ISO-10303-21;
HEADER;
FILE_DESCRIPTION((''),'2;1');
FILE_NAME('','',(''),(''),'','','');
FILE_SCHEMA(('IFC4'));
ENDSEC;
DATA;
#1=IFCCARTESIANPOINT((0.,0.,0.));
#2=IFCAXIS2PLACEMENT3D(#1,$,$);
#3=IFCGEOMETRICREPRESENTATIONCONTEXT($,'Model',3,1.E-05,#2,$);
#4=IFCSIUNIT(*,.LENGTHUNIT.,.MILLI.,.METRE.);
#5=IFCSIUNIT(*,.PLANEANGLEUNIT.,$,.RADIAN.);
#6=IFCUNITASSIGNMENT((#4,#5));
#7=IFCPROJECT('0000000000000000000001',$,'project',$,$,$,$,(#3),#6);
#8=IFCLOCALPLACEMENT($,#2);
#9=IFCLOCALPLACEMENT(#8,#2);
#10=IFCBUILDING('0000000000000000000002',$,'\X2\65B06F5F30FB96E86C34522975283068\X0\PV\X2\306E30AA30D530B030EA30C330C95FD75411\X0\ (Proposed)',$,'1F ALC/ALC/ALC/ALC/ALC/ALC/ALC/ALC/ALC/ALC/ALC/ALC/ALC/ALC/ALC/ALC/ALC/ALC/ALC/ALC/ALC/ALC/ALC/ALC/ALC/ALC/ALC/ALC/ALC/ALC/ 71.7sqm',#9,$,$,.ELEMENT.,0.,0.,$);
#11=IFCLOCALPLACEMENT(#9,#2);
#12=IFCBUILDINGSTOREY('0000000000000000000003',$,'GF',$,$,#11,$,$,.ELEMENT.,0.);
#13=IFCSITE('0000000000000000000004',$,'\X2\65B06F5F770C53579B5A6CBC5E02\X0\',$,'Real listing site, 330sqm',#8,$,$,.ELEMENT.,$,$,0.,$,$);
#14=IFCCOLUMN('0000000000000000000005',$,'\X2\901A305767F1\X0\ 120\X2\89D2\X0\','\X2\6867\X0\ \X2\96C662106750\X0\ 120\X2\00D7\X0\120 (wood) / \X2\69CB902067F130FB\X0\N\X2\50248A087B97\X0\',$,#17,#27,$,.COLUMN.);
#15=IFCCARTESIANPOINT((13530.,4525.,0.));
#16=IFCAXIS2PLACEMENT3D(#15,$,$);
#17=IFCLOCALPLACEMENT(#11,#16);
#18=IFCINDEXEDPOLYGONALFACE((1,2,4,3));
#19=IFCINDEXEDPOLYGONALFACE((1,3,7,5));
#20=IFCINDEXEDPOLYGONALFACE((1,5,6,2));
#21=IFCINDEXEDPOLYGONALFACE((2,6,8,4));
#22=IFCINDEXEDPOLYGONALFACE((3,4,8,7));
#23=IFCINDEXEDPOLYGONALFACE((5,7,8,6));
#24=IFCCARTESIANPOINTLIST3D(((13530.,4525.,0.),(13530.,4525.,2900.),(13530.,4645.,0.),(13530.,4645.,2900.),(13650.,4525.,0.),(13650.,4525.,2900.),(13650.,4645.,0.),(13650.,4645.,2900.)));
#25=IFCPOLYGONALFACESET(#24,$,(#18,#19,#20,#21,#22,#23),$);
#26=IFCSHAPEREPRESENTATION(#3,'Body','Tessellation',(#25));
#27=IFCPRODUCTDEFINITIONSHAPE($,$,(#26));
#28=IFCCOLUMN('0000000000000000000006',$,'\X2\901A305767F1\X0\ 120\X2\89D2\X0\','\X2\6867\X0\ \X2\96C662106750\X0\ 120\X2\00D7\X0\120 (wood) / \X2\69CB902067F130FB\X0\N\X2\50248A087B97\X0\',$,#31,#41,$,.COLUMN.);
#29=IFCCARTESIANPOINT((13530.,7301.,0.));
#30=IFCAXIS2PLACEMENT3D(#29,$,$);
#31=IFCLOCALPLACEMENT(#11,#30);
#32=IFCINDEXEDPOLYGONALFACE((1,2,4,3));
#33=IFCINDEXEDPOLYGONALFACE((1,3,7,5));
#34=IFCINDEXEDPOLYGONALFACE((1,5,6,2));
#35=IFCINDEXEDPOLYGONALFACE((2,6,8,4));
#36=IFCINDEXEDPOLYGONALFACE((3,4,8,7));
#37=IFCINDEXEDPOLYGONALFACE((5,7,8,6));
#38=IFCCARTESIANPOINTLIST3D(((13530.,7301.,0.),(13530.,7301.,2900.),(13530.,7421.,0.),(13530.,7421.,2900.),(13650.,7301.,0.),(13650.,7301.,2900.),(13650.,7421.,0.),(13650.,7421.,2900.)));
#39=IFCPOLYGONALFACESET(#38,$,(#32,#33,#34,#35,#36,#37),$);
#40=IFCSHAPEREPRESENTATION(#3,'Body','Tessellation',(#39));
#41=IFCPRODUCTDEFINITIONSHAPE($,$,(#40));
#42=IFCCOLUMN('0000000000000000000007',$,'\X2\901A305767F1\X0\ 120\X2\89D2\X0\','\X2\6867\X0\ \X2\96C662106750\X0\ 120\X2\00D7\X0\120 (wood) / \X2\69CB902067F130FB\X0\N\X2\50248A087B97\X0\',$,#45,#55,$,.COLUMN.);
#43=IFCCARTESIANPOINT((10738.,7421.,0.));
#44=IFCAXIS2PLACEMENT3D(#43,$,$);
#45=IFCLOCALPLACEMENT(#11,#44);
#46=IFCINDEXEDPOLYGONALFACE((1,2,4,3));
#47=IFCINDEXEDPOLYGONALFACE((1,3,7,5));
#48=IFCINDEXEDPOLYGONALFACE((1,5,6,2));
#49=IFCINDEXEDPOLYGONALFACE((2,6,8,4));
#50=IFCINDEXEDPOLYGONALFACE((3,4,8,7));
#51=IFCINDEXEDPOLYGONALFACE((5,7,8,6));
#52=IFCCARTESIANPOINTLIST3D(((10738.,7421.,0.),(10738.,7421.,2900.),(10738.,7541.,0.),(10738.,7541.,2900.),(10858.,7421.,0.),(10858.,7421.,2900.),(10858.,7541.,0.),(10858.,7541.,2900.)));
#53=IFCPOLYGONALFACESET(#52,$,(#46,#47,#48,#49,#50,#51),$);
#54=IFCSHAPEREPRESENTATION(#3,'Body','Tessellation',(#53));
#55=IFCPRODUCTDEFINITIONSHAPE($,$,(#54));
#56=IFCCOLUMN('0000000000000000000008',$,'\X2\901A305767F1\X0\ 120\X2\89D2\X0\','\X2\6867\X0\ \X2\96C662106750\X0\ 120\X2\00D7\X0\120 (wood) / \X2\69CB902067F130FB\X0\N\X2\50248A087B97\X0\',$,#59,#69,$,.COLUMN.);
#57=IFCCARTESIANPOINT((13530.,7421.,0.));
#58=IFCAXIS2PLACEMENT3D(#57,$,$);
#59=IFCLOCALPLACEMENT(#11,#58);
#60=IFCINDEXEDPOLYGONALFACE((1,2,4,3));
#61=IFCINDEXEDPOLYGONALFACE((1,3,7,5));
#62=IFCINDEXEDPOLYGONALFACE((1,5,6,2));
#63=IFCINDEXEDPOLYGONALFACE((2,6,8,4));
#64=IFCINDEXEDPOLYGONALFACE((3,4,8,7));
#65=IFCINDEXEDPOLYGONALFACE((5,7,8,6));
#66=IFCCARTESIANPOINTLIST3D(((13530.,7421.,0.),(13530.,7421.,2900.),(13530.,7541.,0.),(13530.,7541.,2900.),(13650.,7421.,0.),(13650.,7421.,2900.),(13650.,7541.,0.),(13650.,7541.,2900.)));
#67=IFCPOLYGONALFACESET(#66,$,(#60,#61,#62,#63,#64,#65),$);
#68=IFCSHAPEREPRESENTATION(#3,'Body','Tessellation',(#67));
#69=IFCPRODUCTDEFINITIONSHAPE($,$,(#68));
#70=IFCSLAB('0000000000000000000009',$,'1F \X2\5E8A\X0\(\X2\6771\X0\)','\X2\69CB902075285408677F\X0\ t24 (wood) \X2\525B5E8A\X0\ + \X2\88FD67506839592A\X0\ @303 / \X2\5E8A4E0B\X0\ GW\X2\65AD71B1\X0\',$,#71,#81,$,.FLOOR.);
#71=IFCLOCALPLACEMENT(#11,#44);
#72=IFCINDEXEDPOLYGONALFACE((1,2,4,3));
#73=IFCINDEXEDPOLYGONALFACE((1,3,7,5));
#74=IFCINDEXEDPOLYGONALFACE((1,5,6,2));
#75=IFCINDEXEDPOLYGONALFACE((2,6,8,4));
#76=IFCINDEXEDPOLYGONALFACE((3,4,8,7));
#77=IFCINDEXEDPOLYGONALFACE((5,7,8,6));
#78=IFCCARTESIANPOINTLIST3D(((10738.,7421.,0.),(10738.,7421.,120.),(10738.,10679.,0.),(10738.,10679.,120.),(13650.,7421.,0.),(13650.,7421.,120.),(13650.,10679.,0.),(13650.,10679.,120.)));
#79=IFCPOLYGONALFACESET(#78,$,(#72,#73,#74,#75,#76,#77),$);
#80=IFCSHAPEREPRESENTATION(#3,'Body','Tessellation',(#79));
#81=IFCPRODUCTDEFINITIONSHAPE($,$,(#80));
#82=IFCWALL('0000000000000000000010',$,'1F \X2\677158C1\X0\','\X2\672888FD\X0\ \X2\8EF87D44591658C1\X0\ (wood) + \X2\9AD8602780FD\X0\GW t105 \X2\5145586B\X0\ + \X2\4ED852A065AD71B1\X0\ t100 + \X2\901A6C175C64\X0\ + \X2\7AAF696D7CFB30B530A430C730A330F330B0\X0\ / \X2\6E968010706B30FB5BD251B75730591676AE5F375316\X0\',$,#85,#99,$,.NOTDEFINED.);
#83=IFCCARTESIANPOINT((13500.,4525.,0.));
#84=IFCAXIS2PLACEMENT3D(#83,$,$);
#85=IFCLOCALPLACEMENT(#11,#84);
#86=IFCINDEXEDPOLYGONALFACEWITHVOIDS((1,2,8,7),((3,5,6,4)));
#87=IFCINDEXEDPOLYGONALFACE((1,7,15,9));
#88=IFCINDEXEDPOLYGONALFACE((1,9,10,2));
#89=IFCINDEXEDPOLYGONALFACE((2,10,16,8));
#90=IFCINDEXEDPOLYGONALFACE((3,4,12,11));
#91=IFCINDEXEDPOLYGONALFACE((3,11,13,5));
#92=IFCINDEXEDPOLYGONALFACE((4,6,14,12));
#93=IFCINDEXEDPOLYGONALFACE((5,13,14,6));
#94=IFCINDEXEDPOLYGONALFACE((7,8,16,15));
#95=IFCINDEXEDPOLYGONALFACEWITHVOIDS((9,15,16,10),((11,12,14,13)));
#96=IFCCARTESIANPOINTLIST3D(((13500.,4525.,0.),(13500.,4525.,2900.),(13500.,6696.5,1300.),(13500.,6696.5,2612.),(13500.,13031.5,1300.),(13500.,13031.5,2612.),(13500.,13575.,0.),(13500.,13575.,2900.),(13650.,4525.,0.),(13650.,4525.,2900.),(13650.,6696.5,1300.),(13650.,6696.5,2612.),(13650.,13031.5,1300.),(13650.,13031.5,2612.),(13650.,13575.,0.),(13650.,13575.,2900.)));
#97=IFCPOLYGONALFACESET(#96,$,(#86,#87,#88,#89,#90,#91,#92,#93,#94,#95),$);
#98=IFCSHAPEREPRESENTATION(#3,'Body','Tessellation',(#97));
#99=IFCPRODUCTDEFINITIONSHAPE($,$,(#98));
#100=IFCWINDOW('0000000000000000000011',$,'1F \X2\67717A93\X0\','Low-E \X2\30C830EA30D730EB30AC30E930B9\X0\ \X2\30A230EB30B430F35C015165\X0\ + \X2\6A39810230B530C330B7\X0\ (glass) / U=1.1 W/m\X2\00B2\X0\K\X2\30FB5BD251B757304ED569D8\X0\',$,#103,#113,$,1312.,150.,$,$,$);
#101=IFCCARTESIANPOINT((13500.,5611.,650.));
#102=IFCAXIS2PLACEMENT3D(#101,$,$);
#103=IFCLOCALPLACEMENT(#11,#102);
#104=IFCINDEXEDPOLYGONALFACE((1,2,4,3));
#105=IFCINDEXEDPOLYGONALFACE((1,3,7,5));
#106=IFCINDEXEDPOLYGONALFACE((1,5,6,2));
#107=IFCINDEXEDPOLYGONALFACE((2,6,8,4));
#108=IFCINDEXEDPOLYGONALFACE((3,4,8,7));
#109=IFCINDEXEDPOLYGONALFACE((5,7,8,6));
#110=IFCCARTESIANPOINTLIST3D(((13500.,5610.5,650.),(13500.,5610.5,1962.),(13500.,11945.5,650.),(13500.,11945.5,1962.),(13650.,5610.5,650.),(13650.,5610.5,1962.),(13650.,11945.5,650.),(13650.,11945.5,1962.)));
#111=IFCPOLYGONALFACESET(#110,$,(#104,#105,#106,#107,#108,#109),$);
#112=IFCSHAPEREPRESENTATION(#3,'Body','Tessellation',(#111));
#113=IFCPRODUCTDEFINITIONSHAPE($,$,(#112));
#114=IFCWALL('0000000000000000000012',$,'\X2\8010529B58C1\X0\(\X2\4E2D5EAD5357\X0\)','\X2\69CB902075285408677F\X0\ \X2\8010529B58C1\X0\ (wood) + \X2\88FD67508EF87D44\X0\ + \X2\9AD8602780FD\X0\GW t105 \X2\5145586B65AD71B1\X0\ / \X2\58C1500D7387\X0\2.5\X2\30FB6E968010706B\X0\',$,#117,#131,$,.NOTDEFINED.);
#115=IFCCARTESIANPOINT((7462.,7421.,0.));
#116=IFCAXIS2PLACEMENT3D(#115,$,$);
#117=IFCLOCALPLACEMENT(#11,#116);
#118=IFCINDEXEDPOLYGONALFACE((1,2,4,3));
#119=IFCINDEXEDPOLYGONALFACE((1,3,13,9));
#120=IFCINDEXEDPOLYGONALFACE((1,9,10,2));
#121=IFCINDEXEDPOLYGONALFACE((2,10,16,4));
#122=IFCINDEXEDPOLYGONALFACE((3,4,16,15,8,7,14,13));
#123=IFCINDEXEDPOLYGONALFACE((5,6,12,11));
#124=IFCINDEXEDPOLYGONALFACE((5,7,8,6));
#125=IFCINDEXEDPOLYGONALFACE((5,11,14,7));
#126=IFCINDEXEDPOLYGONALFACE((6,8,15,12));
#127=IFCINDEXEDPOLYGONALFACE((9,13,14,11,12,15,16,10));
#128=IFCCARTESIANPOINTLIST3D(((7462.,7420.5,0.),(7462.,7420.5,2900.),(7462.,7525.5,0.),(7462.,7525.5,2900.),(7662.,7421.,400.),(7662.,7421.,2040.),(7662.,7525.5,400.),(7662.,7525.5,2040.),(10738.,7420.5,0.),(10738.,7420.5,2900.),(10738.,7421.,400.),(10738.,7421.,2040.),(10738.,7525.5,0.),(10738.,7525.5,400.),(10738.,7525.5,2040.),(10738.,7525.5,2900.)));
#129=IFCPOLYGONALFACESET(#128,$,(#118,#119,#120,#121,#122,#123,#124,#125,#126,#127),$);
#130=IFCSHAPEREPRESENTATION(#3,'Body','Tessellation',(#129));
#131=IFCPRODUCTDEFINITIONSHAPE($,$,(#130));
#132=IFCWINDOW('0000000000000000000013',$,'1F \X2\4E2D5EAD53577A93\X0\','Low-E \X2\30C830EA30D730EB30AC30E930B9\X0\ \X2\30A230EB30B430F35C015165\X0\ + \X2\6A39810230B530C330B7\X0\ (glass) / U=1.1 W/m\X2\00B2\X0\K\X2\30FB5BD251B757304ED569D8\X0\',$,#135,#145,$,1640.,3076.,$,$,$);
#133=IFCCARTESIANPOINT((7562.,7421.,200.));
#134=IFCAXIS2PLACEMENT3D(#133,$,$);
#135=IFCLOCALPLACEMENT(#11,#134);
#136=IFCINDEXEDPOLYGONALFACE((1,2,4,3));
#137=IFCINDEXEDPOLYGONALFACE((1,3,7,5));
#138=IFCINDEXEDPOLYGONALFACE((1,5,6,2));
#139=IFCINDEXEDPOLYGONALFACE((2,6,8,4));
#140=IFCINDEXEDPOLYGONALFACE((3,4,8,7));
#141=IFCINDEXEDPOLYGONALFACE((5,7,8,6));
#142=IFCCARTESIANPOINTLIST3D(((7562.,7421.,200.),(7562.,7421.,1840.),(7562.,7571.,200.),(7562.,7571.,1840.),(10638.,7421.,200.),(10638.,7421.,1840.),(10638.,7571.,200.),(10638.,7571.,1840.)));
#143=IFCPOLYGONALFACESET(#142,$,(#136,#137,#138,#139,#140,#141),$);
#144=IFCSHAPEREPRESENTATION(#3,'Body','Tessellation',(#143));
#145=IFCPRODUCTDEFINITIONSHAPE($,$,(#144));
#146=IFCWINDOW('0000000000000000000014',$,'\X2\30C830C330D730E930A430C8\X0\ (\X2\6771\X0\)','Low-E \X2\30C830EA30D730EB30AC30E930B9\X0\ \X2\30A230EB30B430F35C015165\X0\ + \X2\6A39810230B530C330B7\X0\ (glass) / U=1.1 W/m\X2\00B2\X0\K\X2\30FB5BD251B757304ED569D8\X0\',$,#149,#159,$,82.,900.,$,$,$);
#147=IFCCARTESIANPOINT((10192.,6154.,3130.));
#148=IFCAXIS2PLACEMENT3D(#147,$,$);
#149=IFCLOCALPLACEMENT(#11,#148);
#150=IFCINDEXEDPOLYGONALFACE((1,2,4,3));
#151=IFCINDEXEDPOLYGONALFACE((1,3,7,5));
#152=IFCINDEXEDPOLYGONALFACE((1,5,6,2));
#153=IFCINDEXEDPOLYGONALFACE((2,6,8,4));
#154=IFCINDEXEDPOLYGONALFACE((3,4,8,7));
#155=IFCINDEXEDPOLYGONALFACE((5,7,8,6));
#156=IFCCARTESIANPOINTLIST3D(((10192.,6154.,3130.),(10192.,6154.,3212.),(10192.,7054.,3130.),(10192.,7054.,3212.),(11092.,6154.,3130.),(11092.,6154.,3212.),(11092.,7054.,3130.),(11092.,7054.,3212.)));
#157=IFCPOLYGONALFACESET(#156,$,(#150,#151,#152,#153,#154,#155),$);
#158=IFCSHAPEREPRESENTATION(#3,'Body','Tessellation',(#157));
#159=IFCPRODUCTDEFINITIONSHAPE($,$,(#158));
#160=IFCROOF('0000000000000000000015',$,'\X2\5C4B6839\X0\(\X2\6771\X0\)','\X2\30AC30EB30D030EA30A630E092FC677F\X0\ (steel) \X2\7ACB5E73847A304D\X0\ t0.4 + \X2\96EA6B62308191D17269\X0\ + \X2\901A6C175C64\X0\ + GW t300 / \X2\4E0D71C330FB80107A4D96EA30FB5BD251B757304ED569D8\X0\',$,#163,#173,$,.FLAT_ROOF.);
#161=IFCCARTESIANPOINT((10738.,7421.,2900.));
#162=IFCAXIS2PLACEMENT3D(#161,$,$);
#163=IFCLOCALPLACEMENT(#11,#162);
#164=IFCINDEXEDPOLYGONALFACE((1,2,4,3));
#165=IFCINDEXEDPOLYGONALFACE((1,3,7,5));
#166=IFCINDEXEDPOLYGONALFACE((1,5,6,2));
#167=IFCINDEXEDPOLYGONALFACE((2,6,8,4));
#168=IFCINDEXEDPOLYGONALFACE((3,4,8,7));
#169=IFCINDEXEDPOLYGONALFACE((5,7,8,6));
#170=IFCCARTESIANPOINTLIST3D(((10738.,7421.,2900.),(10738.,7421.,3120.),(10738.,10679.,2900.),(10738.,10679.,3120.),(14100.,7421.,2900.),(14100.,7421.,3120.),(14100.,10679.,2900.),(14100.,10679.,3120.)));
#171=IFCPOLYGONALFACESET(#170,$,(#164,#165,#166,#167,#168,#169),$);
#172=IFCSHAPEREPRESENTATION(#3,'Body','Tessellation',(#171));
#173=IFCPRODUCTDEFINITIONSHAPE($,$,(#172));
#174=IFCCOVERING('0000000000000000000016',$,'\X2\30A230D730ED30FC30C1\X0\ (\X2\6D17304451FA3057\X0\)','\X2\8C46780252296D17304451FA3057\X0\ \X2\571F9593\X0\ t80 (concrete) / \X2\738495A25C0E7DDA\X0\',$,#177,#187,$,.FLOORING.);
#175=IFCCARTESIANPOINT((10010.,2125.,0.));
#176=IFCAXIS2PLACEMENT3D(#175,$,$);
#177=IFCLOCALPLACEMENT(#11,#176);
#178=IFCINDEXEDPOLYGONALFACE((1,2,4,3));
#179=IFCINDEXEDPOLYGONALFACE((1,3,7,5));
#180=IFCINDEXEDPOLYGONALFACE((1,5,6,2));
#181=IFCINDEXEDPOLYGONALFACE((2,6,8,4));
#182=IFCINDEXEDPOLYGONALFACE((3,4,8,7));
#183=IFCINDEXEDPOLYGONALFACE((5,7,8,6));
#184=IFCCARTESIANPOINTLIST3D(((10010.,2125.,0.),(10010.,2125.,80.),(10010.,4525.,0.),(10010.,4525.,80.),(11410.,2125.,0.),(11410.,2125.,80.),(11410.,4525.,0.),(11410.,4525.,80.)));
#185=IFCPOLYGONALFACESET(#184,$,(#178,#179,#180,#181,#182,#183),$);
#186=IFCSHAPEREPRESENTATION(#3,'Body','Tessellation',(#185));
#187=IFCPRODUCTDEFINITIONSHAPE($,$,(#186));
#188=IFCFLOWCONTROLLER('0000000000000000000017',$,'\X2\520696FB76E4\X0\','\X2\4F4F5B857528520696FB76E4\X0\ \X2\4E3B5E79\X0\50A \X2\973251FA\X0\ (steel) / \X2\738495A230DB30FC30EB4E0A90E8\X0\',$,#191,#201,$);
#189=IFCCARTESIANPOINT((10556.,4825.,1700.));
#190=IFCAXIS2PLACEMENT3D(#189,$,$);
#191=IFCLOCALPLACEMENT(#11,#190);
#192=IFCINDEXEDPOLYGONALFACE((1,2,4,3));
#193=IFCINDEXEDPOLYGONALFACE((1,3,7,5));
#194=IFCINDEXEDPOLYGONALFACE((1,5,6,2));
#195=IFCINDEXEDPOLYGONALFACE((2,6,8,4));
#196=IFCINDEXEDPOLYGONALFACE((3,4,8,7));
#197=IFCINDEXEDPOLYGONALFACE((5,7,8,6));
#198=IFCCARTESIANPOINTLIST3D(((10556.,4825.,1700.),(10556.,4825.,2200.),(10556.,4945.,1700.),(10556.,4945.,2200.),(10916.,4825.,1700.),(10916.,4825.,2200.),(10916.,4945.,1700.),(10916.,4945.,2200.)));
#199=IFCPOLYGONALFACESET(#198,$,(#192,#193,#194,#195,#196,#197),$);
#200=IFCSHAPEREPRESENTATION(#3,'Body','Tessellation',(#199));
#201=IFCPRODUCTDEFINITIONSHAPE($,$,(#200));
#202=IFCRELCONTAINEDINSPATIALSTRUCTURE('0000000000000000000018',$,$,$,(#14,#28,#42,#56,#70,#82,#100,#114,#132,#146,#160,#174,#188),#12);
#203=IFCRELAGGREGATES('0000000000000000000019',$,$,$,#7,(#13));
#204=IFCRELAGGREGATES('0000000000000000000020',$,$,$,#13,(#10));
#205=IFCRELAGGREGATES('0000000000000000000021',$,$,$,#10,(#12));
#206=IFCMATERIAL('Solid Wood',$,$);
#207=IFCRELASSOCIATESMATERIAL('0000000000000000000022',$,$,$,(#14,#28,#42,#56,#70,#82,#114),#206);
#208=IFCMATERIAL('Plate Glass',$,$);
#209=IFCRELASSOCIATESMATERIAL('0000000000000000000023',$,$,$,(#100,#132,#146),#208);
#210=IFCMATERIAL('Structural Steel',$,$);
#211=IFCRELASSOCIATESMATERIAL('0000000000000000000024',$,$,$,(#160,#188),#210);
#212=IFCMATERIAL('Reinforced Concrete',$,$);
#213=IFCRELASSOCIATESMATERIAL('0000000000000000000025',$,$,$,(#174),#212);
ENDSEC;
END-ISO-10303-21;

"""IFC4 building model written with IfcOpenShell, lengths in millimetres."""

from ifc_helpers import new_model, si_unit, frame, frame_2d, origin, place, context, project, spatial, rectangle, extrude, material, element, fill, save


model = new_model("IFC4")

# Units and contexts
model_context = context("Model", 3, precision=1e-05, world=origin())
ifc_project = project(units=[si_unit("LENGTHUNIT", "METRE", prefix="MILLI"), si_unit("PLANEANGLEUNIT", "RADIAN")], contexts=[model_context])

# Site, building, storey
site_placement = place(None, origin())
site = spatial("IfcSite", under=ifc_project, at=site_placement, Name="新潟県南魚沼市", ObjectType="Real listing site, 330sqm", CompositionType="ELEMENT", RefElevation=0.0)
building_placement = place(site_placement, origin())
building = spatial("IfcBuilding", under=site, at=building_placement, Name="新潟・雨水利用とPVのオフグリッド志向 (Proposed)", ObjectType="1F ALC/ALC/ALC/ALC/ALC/ALC/ALC/ALC/ALC/ALC/ALC/ALC/ALC/ALC/ALC/ALC/ALC/ALC/ALC/ALC/ALC/ALC/ALC/ALC/ALC/ALC/ALC/ALC/ALC/ALC/ 71.7sqm", CompositionType="ELEMENT", ElevationOfRefHeight=0.0, ElevationOfTerrain=0.0)
storey_placement = place(building_placement, origin())
storey = spatial("IfcBuildingStorey", under=building, at=storey_placement, Name="GF", CompositionType="ELEMENT", Elevation=0.0)

# Columns
ifc_material_1 = material(Name="Solid Wood")
column_1_placement = place(storey_placement, frame((13530.0, 4525.0, 0.0)))
element("IfcColumn", 1, at=column_1_placement, inside=storey, material=ifc_material_1, Name="通し柱 120角", Description="桧 集成材 120×120 (wood) / 構造柱・N値計算", PredefinedType="COLUMN", context=model_context, shape_type="SweptSolid", body=[
    extrude(rectangle(XDim=120.0, YDim=120.0, at=frame_2d((60.0, 60.0))), frame((13530.0, 4525.0, 0.0)), (0.0, 0.0, 1.0), 2900.0),
])
column_2_placement = place(storey_placement, frame((13530.0, 7301.0, 0.0)))
element("IfcColumn", 2, at=column_2_placement, inside=storey, material=ifc_material_1, Name="通し柱 120角", Description="桧 集成材 120×120 (wood) / 構造柱・N値計算", PredefinedType="COLUMN", context=model_context, shape_type="SweptSolid", body=[
    extrude(rectangle(XDim=120.0, YDim=120.0, at=frame_2d((60.0, 60.0))), frame((13530.0, 7301.0, 0.0)), (0.0, 0.0, 1.0), 2900.0),
])
column_3_placement = place(storey_placement, frame((10738.0, 7421.0, 0.0)))
element("IfcColumn", 3, at=column_3_placement, inside=storey, material=ifc_material_1, Name="通し柱 120角", Description="桧 集成材 120×120 (wood) / 構造柱・N値計算", PredefinedType="COLUMN", context=model_context, shape_type="SweptSolid", body=[
    extrude(rectangle(XDim=120.0, YDim=120.0, at=frame_2d((60.0, 60.0))), frame((10738.0, 7421.0, 0.0)), (0.0, 0.0, 1.0), 2900.0),
])
column_4_placement = place(storey_placement, frame((13530.0, 7421.0, 0.0)))
element("IfcColumn", 4, at=column_4_placement, inside=storey, material=ifc_material_1, Name="通し柱 120角", Description="桧 集成材 120×120 (wood) / 構造柱・N値計算", PredefinedType="COLUMN", context=model_context, shape_type="SweptSolid", body=[
    extrude(rectangle(XDim=120.0, YDim=120.0, at=frame_2d((60.0, 60.0))), frame((13530.0, 7421.0, 0.0)), (0.0, 0.0, 1.0), 2900.0),
])

# Slab
slab_placement = place(storey_placement, frame((10738.0, 7421.0, 0.0)))
element("IfcSlab", 5, at=slab_placement, inside=storey, material=ifc_material_1, Name="1F 床(東)", Description="構造用合板 t24 (wood) 剛床 + 製材根太 @303 / 床下 GW断熱", PredefinedType="FLOOR", context=model_context, shape_type="SweptSolid", body=[
    extrude(rectangle(XDim=2912.0, YDim=3258.0, at=frame_2d((1456.0, 1629.0))), frame((10738.0, 7421.0, 0.0)), (0.0, 0.0, 1.0), 120.0),
])

# Walls, openings, windows
wall_1_placement = place(storey_placement, frame((13500.0, 4525.0, 0.0)))
wall_1 = element("IfcWall", 6, at=wall_1_placement, inside=storey, material=ifc_material_1, Name="1F 東壁", Description="木製 軸組外壁 (wood) + 高性能GW t105 充填 + 付加断熱 t100 + 通気層 + 窯業系サイディング / 準耐火・寒冷地外皮強化", PredefinedType="NOTDEFINED", context=model_context, shape_type="SweptSolid", body=[
    extrude(rectangle(XDim=150.0, YDim=9050.0, at=frame_2d((75.0, 4525.0))), frame((13500.0, 4525.0, 0.0)), (0.0, 0.0, 1.0), 2900.0),
])
opening_1_placement = place(storey_placement, frame((13500.0, 5611.0, 650.0)))
opening_1 = element("IfcOpeningElement", 7, at=opening_1_placement, cuts=wall_1, PredefinedType="NOTDEFINED", context=model_context, shape_type="SweptSolid", body=[
    extrude(rectangle(XDim=150.0, YDim=6335.0, at=frame_2d((75.0, 3167.0))), frame((13500.0, 5611.0, 650.0)), (0.0, 0.0, 1.0), 1312.0),
])
ifc_material_2 = material(Name="Plate Glass")
window_1_placement = place(storey_placement, frame((13500.0, 5611.0, 650.0)))
window_1 = element("IfcWindow", 8, at=window_1_placement, inside=storey, material=ifc_material_2, Name="1F 東窓", Description="Low-E トリプルガラス アルゴン封入 + 樹脂サッシ (glass) / U=1.1 W/m²K・寒冷地仕様", OverallHeight=1312.0, OverallWidth=150.0, context=model_context, shape_type="SweptSolid", body=[
    extrude(rectangle(XDim=150.0, YDim=6335.0, at=frame_2d((75.0, 3167.0))), frame((13500.0, 5611.0, 650.0)), (0.0, 0.0, 1.0), 1312.0),
])
fill(opening_1, window_1)
wall_2_placement = place(storey_placement, frame((7462.0, 7421.0, 0.0)))
wall_2 = element("IfcWall", 9, at=wall_2_placement, inside=storey, material=ifc_material_1, Name="耐力壁(中庭南)", Description="構造用合板 耐力壁 (wood) + 製材軸組 + 高性能GW t105 充填断熱 / 壁倍率2.5・準耐火", PredefinedType="NOTDEFINED", context=model_context, shape_type="SweptSolid", body=[
    extrude(rectangle(XDim=3276.0, YDim=105.0, at=frame_2d((1638.0, 52.0))), frame((7462.0, 7421.0, 0.0)), (0.0, 0.0, 1.0), 2900.0),
])
opening_2_placement = place(storey_placement, frame((7562.0, 7421.0, 200.0)))
opening_2 = element("IfcOpeningElement", 10, at=opening_2_placement, cuts=wall_2, PredefinedType="NOTDEFINED", context=model_context, shape_type="SweptSolid", body=[
    extrude(rectangle(XDim=3076.0, YDim=150.0, at=frame_2d((1538.0, 75.0))), frame((7562.0, 7421.0, 200.0)), (0.0, 0.0, 1.0), 1640.0),
])
window_2_placement = place(storey_placement, frame((7562.0, 7421.0, 200.0)))
window_2 = element("IfcWindow", 11, at=window_2_placement, inside=storey, material=ifc_material_2, Name="1F 中庭南窓", Description="Low-E トリプルガラス アルゴン封入 + 樹脂サッシ (glass) / U=1.1 W/m²K・寒冷地仕様", OverallHeight=1640.0, OverallWidth=3076.0, context=model_context, shape_type="SweptSolid", body=[
    extrude(rectangle(XDim=3076.0, YDim=150.0, at=frame_2d((1538.0, 75.0))), frame((7562.0, 7421.0, 200.0)), (0.0, 0.0, 1.0), 1640.0),
])
fill(opening_2, window_2)

# Window
window_3_placement = place(storey_placement, frame((10192.0, 6154.0, 3130.0)))
element("IfcWindow", 12, at=window_3_placement, inside=storey, material=ifc_material_2, Name="トップライト (東)", Description="Low-E トリプルガラス アルゴン封入 + 樹脂サッシ (glass) / U=1.1 W/m²K・寒冷地仕様", OverallHeight=82.0, OverallWidth=900.0, context=model_context, shape_type="SweptSolid", body=[
    extrude(rectangle(XDim=900.0, YDim=900.0, at=frame_2d((450.0, 450.0))), frame((10192.0, 6154.0, 3130.0)), (0.0, 0.0, 1.0), 82.0),
])

# Roof
ifc_material_3 = material(Name="Structural Steel")
roof_placement = place(storey_placement, frame((10738.0, 7421.0, 2900.0)))
element("IfcRoof", 13, at=roof_placement, inside=storey, material=ifc_material_3, Name="屋根(東)", Description="ガルバリウム鋼板 (steel) 立平葺き t0.4 + 雪止め金物 + 通気層 + GW t300 / 不燃・耐積雪・寒冷地仕様", PredefinedType="FLAT_ROOF", context=model_context, shape_type="SweptSolid", body=[
    extrude(rectangle(XDim=3362.0, YDim=3258.0, at=frame_2d((1681.0, 1629.0))), frame((10738.0, 7421.0, 2900.0)), (0.0, 0.0, 1.0), 220.0),
])

# Covering
ifc_material_4 = material(Name="Reinforced Concrete")
covering_placement = place(storey_placement, frame((10010.0, 2125.0, 0.0)))
element("IfcCovering", 14, at=covering_placement, inside=storey, material=ifc_material_4, Name="アプローチ (洗い出し)", Description="豆砂利洗い出し 土間 t80 (concrete) / 玄関導線", PredefinedType="FLOORING", context=model_context, shape_type="SweptSolid", body=[
    extrude(rectangle(XDim=1400.0, YDim=2400.0, at=frame_2d((700.0, 1200.0))), frame((10010.0, 2125.0, 0.0)), (0.0, 0.0, 1.0), 80.0),
])

# Flow controller
flow_controller_placement = place(storey_placement, frame((10556.0, 4825.0, 1700.0)))
element("IfcFlowController", 15, at=flow_controller_placement, inside=storey, material=ifc_material_3, Name="分電盤", Description="住宅用分電盤 主幹50A 露出 (steel) / 玄関ホール上部", context=model_context, shape_type="SweptSolid", body=[
    extrude(rectangle(XDim=360.0, YDim=120.0, at=frame_2d((180.0, 60.0))), frame((10556.0, 4825.0, 1700.0)), (0.0, 0.0, 1.0), 500.0),
])

save(model, "model.ifc")
